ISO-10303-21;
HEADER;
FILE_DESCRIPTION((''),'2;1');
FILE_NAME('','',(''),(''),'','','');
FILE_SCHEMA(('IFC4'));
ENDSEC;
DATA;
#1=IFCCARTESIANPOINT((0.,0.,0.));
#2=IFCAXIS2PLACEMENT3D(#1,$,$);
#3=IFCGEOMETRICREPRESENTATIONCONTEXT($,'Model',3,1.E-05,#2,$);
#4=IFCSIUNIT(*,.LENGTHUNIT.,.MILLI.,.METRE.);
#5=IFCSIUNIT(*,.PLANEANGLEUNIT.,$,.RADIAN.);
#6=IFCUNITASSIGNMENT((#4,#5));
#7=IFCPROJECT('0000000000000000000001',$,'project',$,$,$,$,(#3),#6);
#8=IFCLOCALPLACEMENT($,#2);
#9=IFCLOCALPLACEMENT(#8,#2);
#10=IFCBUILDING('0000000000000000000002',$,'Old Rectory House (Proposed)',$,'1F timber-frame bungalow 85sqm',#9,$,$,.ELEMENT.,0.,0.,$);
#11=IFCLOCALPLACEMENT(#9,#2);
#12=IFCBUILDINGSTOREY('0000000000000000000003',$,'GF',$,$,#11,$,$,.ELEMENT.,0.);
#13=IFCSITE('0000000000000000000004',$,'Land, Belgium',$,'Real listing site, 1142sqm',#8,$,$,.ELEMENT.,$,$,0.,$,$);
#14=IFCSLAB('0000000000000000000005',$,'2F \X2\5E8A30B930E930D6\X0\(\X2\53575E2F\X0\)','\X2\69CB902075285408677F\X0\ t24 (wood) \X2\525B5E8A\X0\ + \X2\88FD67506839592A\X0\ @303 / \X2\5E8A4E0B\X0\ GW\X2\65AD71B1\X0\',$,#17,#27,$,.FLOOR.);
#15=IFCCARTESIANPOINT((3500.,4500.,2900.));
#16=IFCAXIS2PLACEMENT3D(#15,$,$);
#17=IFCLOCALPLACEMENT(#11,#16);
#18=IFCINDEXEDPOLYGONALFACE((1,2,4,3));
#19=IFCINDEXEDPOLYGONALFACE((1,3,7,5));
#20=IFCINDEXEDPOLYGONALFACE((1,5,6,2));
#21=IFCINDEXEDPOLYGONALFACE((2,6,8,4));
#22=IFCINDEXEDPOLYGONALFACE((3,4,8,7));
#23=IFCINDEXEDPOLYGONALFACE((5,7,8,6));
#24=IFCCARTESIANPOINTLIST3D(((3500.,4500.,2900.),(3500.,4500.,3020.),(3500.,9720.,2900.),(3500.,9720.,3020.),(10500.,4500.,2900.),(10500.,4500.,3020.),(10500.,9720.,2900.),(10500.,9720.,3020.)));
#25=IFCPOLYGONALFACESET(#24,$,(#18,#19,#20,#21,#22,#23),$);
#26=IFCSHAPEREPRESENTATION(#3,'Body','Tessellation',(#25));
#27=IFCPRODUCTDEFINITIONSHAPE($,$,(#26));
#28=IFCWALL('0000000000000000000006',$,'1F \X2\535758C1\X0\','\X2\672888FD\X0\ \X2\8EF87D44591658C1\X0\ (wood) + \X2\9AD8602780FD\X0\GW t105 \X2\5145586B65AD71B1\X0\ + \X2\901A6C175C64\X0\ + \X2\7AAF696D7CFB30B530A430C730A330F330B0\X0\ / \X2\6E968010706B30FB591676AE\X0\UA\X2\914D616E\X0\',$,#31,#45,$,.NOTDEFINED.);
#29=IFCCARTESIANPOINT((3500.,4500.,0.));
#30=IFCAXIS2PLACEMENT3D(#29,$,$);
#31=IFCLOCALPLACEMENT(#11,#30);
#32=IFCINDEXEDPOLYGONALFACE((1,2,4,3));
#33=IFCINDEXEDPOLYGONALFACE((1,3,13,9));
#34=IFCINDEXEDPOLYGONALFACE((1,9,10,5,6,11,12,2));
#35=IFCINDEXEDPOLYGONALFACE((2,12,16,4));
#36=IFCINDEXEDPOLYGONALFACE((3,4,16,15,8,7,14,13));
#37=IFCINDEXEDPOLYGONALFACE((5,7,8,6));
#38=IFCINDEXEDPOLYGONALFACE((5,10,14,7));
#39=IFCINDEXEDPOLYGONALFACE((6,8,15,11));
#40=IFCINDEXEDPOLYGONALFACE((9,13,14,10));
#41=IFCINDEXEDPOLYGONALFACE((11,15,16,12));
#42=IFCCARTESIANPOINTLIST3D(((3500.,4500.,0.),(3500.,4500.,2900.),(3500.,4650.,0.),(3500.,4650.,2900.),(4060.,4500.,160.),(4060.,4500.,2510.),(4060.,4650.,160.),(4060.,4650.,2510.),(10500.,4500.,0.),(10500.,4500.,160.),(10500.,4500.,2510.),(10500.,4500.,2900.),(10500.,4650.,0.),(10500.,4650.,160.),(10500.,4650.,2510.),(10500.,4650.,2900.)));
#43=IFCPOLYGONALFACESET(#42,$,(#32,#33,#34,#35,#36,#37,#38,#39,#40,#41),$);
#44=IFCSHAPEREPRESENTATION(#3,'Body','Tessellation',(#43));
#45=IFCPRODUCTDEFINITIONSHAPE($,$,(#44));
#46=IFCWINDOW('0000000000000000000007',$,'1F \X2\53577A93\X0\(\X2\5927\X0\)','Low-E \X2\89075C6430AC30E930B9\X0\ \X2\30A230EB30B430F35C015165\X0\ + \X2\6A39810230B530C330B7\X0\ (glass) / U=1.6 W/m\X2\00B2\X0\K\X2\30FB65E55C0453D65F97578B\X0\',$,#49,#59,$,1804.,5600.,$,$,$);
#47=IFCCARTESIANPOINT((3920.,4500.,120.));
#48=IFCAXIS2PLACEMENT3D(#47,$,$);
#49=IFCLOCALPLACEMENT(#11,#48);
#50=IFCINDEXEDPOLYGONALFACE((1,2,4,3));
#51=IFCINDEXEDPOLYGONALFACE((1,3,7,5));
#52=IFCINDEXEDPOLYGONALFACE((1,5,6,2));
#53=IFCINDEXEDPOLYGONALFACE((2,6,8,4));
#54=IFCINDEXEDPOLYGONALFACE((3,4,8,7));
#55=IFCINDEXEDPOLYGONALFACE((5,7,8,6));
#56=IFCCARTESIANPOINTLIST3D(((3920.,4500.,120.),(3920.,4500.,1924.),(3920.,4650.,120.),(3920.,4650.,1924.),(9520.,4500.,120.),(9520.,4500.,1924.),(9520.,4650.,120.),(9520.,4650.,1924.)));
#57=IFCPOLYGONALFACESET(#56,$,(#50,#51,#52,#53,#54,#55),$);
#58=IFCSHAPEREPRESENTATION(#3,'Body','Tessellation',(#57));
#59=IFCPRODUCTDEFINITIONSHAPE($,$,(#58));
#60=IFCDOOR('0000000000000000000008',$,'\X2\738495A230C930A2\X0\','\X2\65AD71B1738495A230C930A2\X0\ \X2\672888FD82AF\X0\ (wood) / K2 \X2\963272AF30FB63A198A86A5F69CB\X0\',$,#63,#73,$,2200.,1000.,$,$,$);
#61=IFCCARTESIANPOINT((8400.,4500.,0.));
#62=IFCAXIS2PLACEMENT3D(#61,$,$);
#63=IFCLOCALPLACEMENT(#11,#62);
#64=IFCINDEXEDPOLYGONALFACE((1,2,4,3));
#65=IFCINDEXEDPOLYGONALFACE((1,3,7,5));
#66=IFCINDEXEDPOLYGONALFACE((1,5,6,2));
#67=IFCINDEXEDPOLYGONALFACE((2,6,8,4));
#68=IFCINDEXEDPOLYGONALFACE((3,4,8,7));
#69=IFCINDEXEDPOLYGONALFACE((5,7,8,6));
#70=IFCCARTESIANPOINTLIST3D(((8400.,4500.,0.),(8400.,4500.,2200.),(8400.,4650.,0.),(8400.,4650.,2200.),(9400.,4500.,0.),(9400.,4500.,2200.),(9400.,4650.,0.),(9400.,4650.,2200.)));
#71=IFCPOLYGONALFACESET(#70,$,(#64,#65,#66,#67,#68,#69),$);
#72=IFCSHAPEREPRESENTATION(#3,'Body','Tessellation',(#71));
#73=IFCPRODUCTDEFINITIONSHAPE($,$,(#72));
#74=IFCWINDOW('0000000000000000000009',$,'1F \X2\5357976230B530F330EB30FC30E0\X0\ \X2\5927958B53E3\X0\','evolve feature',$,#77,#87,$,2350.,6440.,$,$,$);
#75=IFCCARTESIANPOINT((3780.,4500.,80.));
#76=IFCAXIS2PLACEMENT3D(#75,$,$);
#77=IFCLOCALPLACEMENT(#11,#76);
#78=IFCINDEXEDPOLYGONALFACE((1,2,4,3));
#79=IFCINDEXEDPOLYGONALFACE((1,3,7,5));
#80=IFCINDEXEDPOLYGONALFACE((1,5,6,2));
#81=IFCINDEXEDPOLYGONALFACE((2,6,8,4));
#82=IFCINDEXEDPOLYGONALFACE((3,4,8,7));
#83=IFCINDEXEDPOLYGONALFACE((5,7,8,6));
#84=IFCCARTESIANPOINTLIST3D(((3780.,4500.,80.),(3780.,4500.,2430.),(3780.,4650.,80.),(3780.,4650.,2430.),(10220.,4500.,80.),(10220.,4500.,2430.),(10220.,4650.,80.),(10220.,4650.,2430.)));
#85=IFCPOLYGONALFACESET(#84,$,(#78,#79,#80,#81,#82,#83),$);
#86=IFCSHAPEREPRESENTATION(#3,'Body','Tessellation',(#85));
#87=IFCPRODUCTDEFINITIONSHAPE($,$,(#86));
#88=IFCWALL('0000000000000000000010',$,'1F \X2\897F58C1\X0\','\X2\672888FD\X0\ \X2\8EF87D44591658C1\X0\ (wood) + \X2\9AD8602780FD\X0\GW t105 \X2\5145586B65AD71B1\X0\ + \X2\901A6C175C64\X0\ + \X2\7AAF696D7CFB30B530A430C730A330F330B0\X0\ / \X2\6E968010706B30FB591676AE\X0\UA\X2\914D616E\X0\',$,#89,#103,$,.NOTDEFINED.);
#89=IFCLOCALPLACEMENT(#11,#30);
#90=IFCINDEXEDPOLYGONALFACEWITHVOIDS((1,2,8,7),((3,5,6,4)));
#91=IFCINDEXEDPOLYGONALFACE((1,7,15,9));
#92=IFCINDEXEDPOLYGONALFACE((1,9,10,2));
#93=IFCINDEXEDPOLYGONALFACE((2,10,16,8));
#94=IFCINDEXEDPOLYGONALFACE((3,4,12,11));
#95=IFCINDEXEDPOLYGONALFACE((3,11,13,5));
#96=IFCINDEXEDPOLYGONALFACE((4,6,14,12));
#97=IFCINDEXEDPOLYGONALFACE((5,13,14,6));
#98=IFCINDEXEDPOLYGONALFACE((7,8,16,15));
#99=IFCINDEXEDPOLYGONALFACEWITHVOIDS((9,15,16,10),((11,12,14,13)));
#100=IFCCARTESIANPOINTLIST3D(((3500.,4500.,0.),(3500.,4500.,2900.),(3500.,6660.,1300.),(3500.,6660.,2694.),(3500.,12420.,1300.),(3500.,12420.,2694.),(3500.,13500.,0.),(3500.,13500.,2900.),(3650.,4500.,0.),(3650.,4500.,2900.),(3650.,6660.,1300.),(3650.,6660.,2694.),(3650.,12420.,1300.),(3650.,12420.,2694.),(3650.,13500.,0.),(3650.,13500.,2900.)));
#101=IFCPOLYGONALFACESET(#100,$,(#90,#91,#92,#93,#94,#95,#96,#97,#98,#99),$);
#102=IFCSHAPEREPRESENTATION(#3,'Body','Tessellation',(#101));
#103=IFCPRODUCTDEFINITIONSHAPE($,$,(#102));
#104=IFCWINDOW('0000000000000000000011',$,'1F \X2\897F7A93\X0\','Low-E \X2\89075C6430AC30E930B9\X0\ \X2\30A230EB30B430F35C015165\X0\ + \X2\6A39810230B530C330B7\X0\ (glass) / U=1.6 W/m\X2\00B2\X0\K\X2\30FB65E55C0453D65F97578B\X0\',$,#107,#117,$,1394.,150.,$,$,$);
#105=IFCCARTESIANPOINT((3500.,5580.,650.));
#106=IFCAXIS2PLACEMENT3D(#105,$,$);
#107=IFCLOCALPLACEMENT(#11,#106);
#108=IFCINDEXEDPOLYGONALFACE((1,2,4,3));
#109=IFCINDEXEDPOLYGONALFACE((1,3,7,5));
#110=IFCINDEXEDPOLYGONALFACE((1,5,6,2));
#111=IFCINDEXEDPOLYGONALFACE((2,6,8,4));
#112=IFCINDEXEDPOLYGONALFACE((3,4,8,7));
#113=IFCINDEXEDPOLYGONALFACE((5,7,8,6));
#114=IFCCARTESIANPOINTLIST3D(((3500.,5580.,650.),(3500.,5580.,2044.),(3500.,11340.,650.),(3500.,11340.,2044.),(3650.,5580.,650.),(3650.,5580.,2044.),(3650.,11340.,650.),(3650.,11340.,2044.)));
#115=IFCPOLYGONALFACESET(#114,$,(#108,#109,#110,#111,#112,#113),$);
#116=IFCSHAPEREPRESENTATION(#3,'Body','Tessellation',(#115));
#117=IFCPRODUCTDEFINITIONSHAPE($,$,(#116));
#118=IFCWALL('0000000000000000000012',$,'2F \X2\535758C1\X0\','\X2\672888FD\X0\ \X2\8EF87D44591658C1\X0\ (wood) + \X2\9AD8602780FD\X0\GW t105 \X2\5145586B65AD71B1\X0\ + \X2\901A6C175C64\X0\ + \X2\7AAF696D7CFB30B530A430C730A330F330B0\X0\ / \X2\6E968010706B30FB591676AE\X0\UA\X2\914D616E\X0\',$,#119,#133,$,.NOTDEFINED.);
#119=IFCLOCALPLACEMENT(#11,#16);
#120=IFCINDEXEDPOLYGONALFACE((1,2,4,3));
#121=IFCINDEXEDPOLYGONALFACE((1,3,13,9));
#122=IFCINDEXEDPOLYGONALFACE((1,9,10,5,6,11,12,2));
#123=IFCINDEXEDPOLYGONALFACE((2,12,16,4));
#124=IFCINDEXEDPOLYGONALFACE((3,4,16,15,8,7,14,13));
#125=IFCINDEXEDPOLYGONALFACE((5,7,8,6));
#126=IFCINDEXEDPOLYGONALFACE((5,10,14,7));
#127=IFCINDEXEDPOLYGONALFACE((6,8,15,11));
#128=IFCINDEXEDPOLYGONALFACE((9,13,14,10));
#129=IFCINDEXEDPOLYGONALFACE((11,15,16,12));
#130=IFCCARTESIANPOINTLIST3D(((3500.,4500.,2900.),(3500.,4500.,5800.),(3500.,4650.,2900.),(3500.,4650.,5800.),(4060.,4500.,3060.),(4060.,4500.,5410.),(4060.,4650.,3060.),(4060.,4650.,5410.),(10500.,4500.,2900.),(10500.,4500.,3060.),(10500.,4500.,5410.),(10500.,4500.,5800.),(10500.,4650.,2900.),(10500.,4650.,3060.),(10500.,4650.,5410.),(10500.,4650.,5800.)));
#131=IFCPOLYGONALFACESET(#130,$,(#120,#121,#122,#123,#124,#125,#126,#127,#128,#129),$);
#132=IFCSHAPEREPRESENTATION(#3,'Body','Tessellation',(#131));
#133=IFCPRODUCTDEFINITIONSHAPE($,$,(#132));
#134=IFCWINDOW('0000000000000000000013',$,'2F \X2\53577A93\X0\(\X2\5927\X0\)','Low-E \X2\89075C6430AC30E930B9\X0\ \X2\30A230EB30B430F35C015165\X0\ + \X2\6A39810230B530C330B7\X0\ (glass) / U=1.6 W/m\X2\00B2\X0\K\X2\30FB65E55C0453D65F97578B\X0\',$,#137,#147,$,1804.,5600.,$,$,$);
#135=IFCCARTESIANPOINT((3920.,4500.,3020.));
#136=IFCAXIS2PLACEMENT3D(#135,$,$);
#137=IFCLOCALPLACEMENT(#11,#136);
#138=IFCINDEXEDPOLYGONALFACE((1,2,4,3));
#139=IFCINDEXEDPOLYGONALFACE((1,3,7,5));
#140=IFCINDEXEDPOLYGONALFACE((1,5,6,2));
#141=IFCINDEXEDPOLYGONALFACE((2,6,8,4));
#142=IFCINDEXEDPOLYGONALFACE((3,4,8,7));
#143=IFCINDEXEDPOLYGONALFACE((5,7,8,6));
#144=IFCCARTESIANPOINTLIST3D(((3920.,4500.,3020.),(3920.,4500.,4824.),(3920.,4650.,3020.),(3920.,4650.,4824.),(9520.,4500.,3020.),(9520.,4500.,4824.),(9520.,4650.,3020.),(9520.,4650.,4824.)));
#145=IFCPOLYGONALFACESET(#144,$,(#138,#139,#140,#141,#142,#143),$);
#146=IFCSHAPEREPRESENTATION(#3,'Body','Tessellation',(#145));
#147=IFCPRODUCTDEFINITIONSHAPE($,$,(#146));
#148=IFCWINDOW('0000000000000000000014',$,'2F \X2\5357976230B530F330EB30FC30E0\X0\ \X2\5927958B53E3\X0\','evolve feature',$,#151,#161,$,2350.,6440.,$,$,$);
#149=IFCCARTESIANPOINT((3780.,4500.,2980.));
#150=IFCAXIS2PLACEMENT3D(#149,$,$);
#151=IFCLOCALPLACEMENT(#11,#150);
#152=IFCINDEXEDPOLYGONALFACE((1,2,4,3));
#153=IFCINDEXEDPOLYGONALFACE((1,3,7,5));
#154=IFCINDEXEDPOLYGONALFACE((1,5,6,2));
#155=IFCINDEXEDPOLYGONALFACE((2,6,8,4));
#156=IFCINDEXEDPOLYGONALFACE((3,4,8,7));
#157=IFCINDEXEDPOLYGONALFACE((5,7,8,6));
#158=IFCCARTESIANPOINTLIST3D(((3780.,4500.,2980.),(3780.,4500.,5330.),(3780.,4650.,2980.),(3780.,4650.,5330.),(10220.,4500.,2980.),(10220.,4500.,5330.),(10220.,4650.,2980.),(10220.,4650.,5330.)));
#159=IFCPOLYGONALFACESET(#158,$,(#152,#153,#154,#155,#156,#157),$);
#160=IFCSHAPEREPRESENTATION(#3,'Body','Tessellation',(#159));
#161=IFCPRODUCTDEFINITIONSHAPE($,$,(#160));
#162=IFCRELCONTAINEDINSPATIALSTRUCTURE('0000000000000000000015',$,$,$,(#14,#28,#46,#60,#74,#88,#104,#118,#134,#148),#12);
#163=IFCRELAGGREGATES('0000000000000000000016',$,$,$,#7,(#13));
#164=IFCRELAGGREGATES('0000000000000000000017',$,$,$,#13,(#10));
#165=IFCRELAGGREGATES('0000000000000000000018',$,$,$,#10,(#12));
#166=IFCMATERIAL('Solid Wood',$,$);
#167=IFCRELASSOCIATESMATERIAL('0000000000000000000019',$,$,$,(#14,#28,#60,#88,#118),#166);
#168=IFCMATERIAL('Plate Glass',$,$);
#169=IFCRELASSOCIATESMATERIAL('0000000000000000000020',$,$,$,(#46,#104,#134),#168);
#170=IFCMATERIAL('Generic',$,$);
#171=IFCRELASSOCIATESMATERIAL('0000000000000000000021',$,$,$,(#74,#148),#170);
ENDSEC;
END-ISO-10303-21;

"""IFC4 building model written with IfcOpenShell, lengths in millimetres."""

from ifc_helpers import new_model, si_unit, frame, frame_2d, origin, place, context, project, spatial, rectangle, extrude, material, element, fill, save


model = new_model("IFC4")

# Units and contexts
model_context = context("Model", 3, precision=1e-05, world=origin())
ifc_project = project(units=[si_unit("LENGTHUNIT", "METRE", prefix="MILLI"), si_unit("PLANEANGLEUNIT", "RADIAN")], contexts=[model_context])

# Site, building, storey
site_placement = place(None, origin())
site = spatial("IfcSite", under=ifc_project, at=site_placement, Name="Land, Belgium", ObjectType="Real listing site, 1142sqm", CompositionType="ELEMENT", RefElevation=0.0)
building_placement = place(site_placement, origin())
building = spatial("IfcBuilding", under=site, at=building_placement, Name="Old Rectory House (Proposed)", ObjectType="1F timber-frame bungalow 85sqm", CompositionType="ELEMENT", ElevationOfRefHeight=0.0, ElevationOfTerrain=0.0)
storey_placement = place(building_placement, origin())
storey = spatial("IfcBuildingStorey", under=building, at=storey_placement, Name="GF", CompositionType="ELEMENT", Elevation=0.0)

# Slab
ifc_material_1 = material(Name="Solid Wood")
slab_1_placement = place(storey_placement, frame((3500.0, 4500.0, 2900.0)))
element("IfcSlab", 1, at=slab_1_placement, inside=storey, material=ifc_material_1, Name="2F 床スラブ(南帯)", Description="構造用合板 t24 (wood) 剛床 + 製材根太 @303 / 床下 GW断熱", PredefinedType="FLOOR", context=model_context, shape_type="SweptSolid", body=[
    extrude(rectangle(XDim=7000.0, YDim=5220.0, at=frame_2d((3500.0, 2610.0))), frame((3500.0, 4500.0, 2900.0)), (0.0, 0.0, 1.0), 120.0),
])
ifc_material_2 = material(Name="Generic")

# Wall, openings, windows, door
wall_1_placement = place(storey_placement, frame((3500.0, 4500.0, 0.0)))
wall_1 = element("IfcWall", 2, at=wall_1_placement, inside=storey, material=ifc_material_1, Name="1F 南壁", Description="木製 軸組外壁 (wood) + 高性能GW t105 充填断熱 + 通気層 + 窯業系サイディング / 準耐火・外皮UA配慮", PredefinedType="NOTDEFINED", context=model_context, shape_type="SweptSolid", body=[
    extrude(rectangle(XDim=7000.0, YDim=150.0, at=frame_2d((3500.0, 75.0))), frame((3500.0, 4500.0, 0.0)), (0.0, 0.0, 1.0), 2900.0),
])
opening_1_placement = place(storey_placement, frame((3920.0, 4500.0, 120.0)))
opening_1 = element("IfcOpeningElement", 3, at=opening_1_placement, cuts=wall_1, PredefinedType="NOTDEFINED", context=model_context, shape_type="SweptSolid", body=[
    extrude(rectangle(XDim=5600.0, YDim=150.0, at=frame_2d((2800.0, 75.0))), frame((3920.0, 4500.0, 120.0)), (0.0, 0.0, 1.0), 1804.0),
])
opening_2_placement = place(storey_placement, frame((8400.0, 4500.0, 0.0)))
opening_2 = element("IfcOpeningElement", 4, at=opening_2_placement, cuts=wall_1, PredefinedType="NOTDEFINED", context=model_context, shape_type="SweptSolid", body=[
    extrude(rectangle(XDim=1000.0, YDim=150.0, at=frame_2d((500.0, 75.0))), frame((8400.0, 4500.0, 0.0)), (0.0, 0.0, 1.0), 2200.0),
])
opening_3_placement = place(storey_placement, frame((3780.0, 4500.0, 80.0)))
opening_3 = element("IfcOpeningElement", 5, at=opening_3_placement, cuts=wall_1, PredefinedType="NOTDEFINED", context=model_context, shape_type="SweptSolid", body=[
    extrude(rectangle(XDim=6440.0, YDim=150.0, at=frame_2d((3220.0, 75.0))), frame((3780.0, 4500.0, 80.0)), (0.0, 0.0, 1.0), 2350.0),
])
ifc_material_3 = material(Name="Plate Glass")
window_1_placement = place(storey_placement, frame((3920.0, 4500.0, 120.0)))
window_1 = element("IfcWindow", 6, at=window_1_placement, inside=storey, material=ifc_material_3, Name="1F 南窓(大)", Description="Low-E 複層ガラス アルゴン封入 + 樹脂サッシ (glass) / U=1.6 W/m²K・日射取得型", OverallHeight=1804.0, OverallWidth=5600.0, context=model_context, shape_type="SweptSolid", body=[
    extrude(rectangle(XDim=5600.0, YDim=150.0, at=frame_2d((2800.0, 75.0))), frame((3920.0, 4500.0, 120.0)), (0.0, 0.0, 1.0), 1804.0),
])
fill(opening_1, window_1)
door_placement = place(storey_placement, frame((8400.0, 4500.0, 0.0)))
door = element("IfcDoor", 7, at=door_placement, inside=storey, material=ifc_material_1, Name="玄関ドア", Description="断熱玄関ドア 木製芯 (wood) / K2 防犯・採風機構", OverallHeight=2200.0, OverallWidth=1000.0, context=model_context, shape_type="SweptSolid", body=[
    extrude(rectangle(XDim=1000.0, YDim=150.0, at=frame_2d((500.0, 75.0))), frame((8400.0, 4500.0, 0.0)), (0.0, 0.0, 1.0), 2200.0),
])
fill(opening_2, door)
window_2_placement = place(storey_placement, frame((3780.0, 4500.0, 80.0)))
window_2 = element("IfcWindow", 8, at=window_2_placement, inside=storey, material=ifc_material_2, Name="1F 南面サンルーム 大開口", Description="evolve feature", OverallHeight=2350.0, OverallWidth=6440.0, context=model_context, shape_type="SweptSolid", body=[
    extrude(rectangle(XDim=6440.0, YDim=150.0, at=frame_2d((3220.0, 75.0))), frame((3780.0, 4500.0, 80.0)), (0.0, 0.0, 1.0), 2350.0),
])
fill(opening_3, window_2)

# Wall, opening, window
wall_2_placement = place(storey_placement, frame((3500.0, 4500.0, 0.0)))
wall_2 = element("IfcWall", 9, at=wall_2_placement, inside=storey, material=ifc_material_1, Name="1F 西壁", Description="木製 軸組外壁 (wood) + 高性能GW t105 充填断熱 + 通気層 + 窯業系サイディング / 準耐火・外皮UA配慮", PredefinedType="NOTDEFINED", context=model_context, shape_type="SweptSolid", body=[
    extrude(rectangle(XDim=150.0, YDim=9000.0, at=frame_2d((75.0, 4500.0))), frame((3500.0, 4500.0, 0.0)), (0.0, 0.0, 1.0), 2900.0),
])
opening_4_placement = place(storey_placement, frame((3500.0, 5580.0, 650.0)))
opening_4 = element("IfcOpeningElement", 10, at=opening_4_placement, cuts=wall_2, PredefinedType="NOTDEFINED", context=model_context, shape_type="SweptSolid", body=[
    extrude(rectangle(XDim=150.0, YDim=5760.0, at=frame_2d((75.0, 2880.0))), frame((3500.0, 5580.0, 650.0)), (0.0, 0.0, 1.0), 1394.0),
])
window_3_placement = place(storey_placement, frame((3500.0, 5580.0, 650.0)))
window_3 = element("IfcWindow", 11, at=window_3_placement, inside=storey, material=ifc_material_3, Name="1F 西窓", Description="Low-E 複層ガラス アルゴン封入 + 樹脂サッシ (glass) / U=1.6 W/m²K・日射取得型", OverallHeight=1394.0, OverallWidth=150.0, context=model_context, shape_type="SweptSolid", body=[
    extrude(rectangle(XDim=150.0, YDim=5760.0, at=frame_2d((75.0, 2880.0))), frame((3500.0, 5580.0, 650.0)), (0.0, 0.0, 1.0), 1394.0),
])
fill(opening_4, window_3)

# Wall, openings, windows
wall_3_placement = place(storey_placement, frame((3500.0, 4500.0, 2900.0)))
wall_3 = element("IfcWall", 12, at=wall_3_placement, inside=storey, material=ifc_material_1, Name="2F 南壁", Description="木製 軸組外壁 (wood) + 高性能GW t105 充填断熱 + 通気層 + 窯業系サイディング / 準耐火・外皮UA配慮", PredefinedType="NOTDEFINED", context=model_context, shape_type="SweptSolid", body=[
    extrude(rectangle(XDim=7000.0, YDim=150.0, at=frame_2d((3500.0, 75.0))), frame((3500.0, 4500.0, 2900.0)), (0.0, 0.0, 1.0), 2900.0),
])
opening_5_placement = place(storey_placement, frame((3920.0, 4500.0, 3020.0)))
opening_5 = element("IfcOpeningElement", 13, at=opening_5_placement, cuts=wall_3, PredefinedType="NOTDEFINED", context=model_context, shape_type="SweptSolid", body=[
    extrude(rectangle(XDim=5600.0, YDim=150.0, at=frame_2d((2800.0, 75.0))), frame((3920.0, 4500.0, 3020.0)), (0.0, 0.0, 1.0), 1804.0),
])
opening_6_placement = place(storey_placement, frame((3780.0, 4500.0, 2980.0)))
opening_6 = element("IfcOpeningElement", 14, at=opening_6_placement, cuts=wall_3, PredefinedType="NOTDEFINED", context=model_context, shape_type="SweptSolid", body=[
    extrude(rectangle(XDim=6440.0, YDim=150.0, at=frame_2d((3220.0, 75.0))), frame((3780.0, 4500.0, 2980.0)), (0.0, 0.0, 1.0), 2350.0),
])
window_4_placement = place(storey_placement, frame((3920.0, 4500.0, 3020.0)))
window_4 = element("IfcWindow", 15, at=window_4_placement, inside=storey, material=ifc_material_3, Name="2F 南窓(大)", Description="Low-E 複層ガラス アルゴン封入 + 樹脂サッシ (glass) / U=1.6 W/m²K・日射取得型", OverallHeight=1804.0, OverallWidth=5600.0, context=model_context, shape_type="SweptSolid", body=[
    extrude(rectangle(XDim=5600.0, YDim=150.0, at=frame_2d((2800.0, 75.0))), frame((3920.0, 4500.0, 3020.0)), (0.0, 0.0, 1.0), 1804.0),
])
fill(opening_5, window_4)
window_5_placement = place(storey_placement, frame((3780.0, 4500.0, 2980.0)))
window_5 = element("IfcWindow", 16, at=window_5_placement, inside=storey, material=ifc_material_2, Name="2F 南面サンルーム 大開口", Description="evolve feature", OverallHeight=2350.0, OverallWidth=6440.0, context=model_context, shape_type="SweptSolid", body=[
    extrude(rectangle(XDim=6440.0, YDim=150.0, at=frame_2d((3220.0, 75.0))), frame((3780.0, 4500.0, 2980.0)), (0.0, 0.0, 1.0), 2350.0),
])
fill(opening_6, window_5)

save(model, "model.ifc")
